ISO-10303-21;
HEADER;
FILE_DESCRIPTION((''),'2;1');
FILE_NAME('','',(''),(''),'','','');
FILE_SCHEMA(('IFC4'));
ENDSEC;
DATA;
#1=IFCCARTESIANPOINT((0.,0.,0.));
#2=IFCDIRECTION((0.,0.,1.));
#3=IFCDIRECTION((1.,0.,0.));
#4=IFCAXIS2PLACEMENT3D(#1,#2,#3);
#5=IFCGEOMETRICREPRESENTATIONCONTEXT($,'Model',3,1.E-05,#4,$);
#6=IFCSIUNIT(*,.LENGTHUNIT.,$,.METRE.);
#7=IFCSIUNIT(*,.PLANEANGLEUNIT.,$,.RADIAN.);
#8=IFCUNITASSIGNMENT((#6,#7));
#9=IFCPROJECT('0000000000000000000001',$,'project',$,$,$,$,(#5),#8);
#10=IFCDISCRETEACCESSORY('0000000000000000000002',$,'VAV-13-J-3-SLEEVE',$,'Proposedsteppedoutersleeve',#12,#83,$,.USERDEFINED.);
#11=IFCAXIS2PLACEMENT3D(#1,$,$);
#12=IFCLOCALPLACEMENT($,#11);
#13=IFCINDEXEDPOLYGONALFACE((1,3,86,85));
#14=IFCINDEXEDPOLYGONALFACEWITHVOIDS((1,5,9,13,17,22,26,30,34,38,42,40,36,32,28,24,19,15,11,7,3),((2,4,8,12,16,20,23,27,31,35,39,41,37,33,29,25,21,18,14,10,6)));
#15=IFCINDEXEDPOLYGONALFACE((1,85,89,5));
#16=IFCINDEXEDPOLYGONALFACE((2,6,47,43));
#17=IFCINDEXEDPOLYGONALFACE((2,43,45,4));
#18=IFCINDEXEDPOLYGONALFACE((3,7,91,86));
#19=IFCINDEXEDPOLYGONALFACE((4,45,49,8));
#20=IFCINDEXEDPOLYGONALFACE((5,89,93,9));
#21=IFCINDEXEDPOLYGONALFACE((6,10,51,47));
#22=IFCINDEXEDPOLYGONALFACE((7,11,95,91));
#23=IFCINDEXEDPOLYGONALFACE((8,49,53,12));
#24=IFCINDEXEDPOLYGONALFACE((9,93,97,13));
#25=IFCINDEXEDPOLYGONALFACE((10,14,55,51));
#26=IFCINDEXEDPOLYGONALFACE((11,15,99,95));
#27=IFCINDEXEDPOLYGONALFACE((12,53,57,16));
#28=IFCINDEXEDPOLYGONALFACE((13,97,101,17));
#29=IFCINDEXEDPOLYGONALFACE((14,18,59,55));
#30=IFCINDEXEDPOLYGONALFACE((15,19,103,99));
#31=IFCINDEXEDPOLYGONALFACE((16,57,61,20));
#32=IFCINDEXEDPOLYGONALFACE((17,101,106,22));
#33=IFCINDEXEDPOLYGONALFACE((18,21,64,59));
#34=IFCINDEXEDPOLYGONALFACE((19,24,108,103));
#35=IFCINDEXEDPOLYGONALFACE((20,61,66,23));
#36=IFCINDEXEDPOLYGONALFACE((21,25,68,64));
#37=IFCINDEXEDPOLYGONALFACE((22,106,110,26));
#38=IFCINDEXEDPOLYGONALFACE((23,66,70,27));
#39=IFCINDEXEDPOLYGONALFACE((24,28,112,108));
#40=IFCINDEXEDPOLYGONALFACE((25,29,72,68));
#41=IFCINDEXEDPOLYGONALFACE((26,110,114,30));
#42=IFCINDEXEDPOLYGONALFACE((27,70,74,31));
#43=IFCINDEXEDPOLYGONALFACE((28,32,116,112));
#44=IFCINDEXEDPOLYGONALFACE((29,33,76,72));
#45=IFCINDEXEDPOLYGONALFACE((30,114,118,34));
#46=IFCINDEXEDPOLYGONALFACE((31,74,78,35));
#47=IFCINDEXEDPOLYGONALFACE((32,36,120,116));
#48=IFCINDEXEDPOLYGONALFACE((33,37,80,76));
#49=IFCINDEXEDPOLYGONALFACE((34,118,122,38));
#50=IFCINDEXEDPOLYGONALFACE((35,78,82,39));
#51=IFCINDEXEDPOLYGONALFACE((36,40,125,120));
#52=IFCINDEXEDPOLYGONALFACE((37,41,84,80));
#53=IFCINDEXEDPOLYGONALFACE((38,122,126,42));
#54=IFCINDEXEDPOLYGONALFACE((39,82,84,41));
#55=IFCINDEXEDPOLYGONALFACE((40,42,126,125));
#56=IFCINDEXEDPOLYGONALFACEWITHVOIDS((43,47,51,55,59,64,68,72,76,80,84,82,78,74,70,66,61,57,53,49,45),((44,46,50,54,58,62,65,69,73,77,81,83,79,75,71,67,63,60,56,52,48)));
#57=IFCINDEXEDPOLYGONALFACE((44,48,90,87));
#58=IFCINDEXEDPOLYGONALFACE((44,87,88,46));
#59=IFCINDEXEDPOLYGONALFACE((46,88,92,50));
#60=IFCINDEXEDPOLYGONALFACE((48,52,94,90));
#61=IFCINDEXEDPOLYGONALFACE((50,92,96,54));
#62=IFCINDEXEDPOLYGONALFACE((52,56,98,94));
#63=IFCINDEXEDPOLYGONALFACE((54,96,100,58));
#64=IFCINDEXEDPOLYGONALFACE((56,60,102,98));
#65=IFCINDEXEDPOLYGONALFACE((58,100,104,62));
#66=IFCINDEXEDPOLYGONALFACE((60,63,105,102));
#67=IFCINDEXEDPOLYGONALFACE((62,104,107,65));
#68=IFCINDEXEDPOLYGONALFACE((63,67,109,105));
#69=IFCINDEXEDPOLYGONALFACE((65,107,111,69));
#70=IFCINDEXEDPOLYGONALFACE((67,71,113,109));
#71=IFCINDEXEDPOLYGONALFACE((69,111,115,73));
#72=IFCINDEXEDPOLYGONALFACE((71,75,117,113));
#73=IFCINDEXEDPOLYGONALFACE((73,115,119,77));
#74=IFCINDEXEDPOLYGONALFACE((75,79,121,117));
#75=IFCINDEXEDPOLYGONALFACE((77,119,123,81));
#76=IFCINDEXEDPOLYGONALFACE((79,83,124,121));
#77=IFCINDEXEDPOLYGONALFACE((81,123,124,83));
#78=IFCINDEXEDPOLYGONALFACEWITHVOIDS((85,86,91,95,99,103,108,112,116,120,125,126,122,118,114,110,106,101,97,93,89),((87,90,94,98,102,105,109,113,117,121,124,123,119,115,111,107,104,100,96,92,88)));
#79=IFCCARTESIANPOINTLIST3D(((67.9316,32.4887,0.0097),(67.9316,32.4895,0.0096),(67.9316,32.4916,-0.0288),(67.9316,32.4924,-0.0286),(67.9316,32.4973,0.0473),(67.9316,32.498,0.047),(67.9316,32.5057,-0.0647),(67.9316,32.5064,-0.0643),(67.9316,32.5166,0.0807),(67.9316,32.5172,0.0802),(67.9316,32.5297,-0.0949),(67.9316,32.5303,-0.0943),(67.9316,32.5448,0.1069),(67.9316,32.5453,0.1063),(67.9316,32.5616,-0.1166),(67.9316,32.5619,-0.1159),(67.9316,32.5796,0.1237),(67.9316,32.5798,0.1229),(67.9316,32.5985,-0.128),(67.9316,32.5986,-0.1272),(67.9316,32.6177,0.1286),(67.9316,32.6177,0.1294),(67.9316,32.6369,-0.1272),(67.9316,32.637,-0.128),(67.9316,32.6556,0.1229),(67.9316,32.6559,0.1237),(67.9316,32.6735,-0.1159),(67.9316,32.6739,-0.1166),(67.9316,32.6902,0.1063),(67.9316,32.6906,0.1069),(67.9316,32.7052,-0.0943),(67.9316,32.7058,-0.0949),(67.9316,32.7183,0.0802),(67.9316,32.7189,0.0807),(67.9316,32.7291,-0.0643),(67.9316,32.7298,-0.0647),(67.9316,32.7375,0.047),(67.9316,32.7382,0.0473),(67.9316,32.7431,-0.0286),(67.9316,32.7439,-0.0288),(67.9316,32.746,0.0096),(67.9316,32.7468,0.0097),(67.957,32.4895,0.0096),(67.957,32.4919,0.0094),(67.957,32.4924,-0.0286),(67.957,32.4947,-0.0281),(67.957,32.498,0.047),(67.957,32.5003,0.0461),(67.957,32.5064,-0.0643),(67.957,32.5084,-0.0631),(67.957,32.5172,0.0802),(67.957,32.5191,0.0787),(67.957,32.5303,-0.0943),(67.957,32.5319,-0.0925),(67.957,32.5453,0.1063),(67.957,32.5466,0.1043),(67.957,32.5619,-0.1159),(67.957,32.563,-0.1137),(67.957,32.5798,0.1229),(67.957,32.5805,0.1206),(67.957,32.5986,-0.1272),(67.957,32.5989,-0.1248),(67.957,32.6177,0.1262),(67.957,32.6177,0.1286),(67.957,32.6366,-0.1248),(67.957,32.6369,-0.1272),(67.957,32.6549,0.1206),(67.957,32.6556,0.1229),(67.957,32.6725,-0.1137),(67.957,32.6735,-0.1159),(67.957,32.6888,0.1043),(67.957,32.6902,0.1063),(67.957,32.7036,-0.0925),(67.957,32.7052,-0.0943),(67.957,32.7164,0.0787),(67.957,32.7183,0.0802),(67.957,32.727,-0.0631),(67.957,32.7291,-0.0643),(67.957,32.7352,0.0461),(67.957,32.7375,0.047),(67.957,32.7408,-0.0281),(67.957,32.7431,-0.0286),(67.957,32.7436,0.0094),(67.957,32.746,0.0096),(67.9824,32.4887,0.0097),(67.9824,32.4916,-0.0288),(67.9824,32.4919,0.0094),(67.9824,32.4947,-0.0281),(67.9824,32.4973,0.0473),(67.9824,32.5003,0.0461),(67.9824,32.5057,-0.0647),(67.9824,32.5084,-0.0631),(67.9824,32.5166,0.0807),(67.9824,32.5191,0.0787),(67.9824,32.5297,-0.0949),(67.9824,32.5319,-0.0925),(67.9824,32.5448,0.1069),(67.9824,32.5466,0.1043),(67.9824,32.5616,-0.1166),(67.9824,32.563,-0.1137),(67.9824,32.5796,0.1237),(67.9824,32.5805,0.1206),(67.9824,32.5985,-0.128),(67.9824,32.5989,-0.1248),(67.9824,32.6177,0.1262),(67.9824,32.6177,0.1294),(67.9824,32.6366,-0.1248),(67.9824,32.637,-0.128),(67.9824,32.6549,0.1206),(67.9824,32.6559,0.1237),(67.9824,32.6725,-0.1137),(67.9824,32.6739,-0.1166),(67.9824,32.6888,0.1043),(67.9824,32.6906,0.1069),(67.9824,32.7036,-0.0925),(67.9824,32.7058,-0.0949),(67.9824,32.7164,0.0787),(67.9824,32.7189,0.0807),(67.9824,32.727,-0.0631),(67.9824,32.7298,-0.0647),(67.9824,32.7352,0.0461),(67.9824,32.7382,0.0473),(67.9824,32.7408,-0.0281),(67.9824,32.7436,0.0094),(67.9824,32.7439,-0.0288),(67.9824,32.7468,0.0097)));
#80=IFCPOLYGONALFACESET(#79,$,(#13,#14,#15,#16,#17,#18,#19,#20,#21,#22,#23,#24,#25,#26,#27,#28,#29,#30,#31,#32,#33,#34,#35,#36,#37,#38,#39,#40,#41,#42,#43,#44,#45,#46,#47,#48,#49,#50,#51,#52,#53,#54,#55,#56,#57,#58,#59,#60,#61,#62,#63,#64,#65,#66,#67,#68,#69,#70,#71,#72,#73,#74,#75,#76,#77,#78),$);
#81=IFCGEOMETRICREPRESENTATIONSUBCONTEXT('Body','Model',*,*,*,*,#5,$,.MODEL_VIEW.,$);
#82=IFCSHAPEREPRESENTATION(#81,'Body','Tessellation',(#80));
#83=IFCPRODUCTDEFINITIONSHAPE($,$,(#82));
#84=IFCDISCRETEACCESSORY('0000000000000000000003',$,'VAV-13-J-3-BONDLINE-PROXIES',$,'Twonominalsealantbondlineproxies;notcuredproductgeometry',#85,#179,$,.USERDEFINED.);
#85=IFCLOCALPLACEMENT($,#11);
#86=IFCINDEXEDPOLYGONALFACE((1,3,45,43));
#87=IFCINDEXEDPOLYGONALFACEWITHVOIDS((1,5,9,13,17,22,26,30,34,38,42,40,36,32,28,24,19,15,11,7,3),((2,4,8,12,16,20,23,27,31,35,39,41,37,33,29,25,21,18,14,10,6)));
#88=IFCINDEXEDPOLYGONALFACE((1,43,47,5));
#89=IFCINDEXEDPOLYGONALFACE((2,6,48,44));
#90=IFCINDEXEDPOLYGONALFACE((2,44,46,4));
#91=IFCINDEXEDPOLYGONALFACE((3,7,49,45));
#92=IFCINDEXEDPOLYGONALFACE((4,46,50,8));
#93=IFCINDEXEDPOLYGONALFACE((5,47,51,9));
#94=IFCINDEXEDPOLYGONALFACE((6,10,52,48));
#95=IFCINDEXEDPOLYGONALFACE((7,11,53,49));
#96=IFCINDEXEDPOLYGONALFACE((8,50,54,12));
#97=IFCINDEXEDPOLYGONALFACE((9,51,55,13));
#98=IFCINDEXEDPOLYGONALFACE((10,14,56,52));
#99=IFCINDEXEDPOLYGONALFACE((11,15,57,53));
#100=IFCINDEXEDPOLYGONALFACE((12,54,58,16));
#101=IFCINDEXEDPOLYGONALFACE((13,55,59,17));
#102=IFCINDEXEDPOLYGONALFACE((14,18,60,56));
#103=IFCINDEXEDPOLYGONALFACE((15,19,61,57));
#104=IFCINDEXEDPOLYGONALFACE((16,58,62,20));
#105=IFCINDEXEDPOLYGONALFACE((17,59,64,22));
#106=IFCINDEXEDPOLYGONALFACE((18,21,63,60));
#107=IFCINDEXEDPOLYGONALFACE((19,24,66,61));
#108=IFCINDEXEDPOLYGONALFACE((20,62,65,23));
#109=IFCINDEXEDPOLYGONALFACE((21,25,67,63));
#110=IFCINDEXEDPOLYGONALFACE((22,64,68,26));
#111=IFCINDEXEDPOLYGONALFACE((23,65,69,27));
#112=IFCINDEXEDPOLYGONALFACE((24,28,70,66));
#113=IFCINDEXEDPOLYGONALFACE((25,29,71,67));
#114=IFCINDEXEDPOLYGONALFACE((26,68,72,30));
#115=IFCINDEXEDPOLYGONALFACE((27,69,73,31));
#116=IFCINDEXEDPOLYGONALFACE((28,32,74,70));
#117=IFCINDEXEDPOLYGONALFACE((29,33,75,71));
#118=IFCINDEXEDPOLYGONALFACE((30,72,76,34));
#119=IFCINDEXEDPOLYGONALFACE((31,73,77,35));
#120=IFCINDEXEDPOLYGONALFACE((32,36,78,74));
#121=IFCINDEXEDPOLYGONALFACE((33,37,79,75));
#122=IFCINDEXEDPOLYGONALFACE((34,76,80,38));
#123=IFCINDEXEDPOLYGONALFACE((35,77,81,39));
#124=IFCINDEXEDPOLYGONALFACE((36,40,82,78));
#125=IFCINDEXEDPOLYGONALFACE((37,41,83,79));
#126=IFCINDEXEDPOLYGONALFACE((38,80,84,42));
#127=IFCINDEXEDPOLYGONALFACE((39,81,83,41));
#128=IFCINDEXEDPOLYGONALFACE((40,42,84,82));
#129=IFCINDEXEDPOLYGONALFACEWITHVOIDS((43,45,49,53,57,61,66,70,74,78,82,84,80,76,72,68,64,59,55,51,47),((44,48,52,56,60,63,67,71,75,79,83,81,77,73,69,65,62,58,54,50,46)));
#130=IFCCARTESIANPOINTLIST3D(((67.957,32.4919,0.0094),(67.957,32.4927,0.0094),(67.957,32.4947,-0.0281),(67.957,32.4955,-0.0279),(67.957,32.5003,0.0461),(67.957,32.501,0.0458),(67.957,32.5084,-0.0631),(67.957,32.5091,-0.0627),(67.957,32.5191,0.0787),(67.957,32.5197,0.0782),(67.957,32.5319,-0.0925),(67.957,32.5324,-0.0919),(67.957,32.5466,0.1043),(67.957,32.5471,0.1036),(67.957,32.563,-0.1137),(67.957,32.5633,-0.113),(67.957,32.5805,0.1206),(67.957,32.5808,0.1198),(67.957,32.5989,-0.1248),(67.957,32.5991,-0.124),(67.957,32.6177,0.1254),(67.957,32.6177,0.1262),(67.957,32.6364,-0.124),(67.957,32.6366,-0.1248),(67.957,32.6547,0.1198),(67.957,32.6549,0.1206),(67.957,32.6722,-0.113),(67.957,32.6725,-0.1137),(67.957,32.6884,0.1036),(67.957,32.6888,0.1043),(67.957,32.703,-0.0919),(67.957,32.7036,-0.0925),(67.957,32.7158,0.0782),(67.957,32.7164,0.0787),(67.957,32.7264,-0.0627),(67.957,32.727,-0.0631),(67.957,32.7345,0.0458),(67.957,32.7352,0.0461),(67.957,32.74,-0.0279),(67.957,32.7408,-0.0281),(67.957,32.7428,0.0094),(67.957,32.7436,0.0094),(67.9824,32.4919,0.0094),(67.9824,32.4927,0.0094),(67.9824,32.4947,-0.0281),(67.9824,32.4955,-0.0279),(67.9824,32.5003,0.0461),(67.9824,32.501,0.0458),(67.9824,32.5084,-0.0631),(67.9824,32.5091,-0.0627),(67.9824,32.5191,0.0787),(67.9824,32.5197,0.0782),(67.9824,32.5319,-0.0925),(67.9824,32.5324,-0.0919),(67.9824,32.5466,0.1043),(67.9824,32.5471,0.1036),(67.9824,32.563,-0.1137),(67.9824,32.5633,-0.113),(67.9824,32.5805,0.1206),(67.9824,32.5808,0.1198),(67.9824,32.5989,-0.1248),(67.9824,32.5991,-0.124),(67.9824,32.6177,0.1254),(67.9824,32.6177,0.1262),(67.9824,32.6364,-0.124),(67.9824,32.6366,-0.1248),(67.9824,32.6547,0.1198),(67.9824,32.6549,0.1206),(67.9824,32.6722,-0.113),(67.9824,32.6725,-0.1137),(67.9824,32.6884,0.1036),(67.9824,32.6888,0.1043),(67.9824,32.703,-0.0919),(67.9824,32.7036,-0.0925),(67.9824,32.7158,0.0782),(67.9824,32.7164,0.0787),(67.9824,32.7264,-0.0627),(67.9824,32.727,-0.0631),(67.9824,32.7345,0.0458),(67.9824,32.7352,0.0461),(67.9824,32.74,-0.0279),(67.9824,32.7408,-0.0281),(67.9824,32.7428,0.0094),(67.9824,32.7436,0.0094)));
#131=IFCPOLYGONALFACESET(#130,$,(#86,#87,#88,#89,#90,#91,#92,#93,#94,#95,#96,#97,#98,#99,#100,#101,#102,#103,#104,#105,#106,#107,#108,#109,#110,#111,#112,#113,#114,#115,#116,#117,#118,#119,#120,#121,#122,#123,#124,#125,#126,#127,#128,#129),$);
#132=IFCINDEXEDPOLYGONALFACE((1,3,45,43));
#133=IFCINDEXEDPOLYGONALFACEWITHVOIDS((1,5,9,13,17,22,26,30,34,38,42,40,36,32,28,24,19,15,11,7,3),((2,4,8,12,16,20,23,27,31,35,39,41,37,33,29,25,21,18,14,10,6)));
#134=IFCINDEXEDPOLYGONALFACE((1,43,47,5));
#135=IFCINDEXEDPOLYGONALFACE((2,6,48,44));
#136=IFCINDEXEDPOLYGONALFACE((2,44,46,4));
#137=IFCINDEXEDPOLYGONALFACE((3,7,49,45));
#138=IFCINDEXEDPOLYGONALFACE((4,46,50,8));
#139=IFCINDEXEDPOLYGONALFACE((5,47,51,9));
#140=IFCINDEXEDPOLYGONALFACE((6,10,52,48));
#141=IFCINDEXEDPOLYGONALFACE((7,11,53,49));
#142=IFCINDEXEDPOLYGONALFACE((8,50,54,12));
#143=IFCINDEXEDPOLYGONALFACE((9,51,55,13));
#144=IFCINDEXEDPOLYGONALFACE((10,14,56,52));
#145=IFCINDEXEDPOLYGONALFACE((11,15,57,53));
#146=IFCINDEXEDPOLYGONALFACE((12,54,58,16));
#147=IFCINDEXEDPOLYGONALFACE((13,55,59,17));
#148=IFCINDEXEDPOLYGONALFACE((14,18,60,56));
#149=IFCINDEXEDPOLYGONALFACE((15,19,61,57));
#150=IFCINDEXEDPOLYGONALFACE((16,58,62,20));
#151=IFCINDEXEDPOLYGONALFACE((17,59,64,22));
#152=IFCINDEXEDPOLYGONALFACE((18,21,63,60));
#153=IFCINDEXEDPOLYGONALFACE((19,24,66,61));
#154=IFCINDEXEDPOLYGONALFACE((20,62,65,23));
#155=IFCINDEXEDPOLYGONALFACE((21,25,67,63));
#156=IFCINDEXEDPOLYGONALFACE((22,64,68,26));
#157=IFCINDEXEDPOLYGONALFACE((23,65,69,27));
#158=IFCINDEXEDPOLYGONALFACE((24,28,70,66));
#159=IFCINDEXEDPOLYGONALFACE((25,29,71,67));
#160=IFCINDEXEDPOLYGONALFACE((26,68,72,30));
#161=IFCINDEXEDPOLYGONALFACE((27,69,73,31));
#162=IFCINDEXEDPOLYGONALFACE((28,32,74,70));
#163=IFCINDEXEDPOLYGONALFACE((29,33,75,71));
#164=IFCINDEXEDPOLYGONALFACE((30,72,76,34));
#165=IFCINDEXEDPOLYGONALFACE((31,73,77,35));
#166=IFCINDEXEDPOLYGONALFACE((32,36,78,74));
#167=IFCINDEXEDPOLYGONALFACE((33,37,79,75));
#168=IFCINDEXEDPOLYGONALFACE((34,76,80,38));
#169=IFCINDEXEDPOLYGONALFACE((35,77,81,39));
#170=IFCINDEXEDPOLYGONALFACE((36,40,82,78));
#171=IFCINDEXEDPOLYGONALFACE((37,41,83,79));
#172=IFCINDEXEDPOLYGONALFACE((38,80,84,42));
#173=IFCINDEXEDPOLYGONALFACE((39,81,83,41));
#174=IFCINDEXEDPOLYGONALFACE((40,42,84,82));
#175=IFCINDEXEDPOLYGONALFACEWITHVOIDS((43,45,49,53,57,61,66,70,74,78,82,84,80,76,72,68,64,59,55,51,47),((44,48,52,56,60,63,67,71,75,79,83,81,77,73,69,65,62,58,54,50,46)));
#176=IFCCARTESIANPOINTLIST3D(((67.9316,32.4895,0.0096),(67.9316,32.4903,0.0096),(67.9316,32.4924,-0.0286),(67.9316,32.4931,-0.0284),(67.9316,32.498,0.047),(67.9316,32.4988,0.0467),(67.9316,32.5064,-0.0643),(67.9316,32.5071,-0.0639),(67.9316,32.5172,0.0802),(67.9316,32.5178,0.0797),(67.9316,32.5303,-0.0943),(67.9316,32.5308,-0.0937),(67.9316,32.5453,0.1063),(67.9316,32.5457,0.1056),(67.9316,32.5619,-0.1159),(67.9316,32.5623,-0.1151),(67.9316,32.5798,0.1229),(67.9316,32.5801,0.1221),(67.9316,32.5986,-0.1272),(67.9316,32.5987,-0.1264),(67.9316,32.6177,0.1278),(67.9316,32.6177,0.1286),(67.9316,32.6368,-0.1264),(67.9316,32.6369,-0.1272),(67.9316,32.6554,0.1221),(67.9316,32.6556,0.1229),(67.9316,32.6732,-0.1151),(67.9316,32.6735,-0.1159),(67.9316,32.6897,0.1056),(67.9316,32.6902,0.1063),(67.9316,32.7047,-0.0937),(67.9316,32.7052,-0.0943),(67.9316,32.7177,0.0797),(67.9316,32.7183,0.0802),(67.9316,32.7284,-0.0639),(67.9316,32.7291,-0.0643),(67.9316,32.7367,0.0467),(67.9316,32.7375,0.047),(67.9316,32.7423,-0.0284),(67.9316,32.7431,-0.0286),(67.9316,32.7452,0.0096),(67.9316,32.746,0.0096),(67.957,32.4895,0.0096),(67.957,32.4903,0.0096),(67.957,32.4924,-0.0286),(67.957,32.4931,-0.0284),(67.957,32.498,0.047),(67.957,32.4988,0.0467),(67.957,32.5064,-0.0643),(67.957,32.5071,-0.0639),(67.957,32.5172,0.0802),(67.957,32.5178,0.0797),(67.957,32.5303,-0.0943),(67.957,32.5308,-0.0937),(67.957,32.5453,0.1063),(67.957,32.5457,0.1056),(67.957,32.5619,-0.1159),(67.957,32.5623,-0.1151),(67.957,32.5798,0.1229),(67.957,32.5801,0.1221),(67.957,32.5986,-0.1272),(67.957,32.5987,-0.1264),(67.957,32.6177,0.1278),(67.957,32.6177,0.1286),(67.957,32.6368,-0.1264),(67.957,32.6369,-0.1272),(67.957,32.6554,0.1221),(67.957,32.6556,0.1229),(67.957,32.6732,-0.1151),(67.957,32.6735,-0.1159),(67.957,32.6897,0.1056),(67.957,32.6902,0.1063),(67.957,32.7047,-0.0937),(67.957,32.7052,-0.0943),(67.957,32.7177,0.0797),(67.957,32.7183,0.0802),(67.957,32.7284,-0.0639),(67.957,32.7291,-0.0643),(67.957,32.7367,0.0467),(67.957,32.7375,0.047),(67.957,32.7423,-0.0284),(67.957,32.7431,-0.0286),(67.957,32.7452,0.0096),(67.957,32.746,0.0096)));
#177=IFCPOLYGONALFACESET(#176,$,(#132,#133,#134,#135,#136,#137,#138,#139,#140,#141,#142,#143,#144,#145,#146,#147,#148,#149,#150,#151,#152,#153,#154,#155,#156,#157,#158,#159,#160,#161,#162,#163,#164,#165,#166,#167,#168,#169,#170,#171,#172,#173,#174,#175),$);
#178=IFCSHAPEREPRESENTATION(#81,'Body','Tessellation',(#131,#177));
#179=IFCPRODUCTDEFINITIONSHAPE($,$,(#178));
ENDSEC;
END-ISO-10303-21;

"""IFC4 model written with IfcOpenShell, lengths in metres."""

from ifc_helpers import new_model, entity, si_unit, frame, origin_with_axes, place, context, subcontext, project, element, save


model = new_model("IFC4")

# Units and contexts
model_context = context("Model", 3, precision=1e-05, world=origin_with_axes())
body_context = subcontext(model_context, "Body", "Model", "MODEL_VIEW")
ifc_project = project(units=[si_unit("LENGTHUNIT", "METRE"), si_unit("PLANEANGLEUNIT", "RADIAN")], contexts=[model_context])

# Discrete accessories
discrete_accessory_1_placement = place(None, frame((67.957, 32.6177, 0.0), z_axis=(0.0, -1.0, 0.0), x_axis=(0.0, 0.0, 1.0)))
element("IfcDiscreteAccessory", 1, at=discrete_accessory_1_placement, Name="VAV-13-J-3-SLEEVE", ObjectType="Proposedsteppedoutersleeve", PredefinedType="USERDEFINED", context=body_context, shape_type="SweptSolid", body=[
    entity("IfcRevolvedAreaSolid", entity("IfcArbitraryClosedProfileDef", "AREA", None, entity("IfcPolyline", [entity("IfcCartesianPoint", [0.1262, -0.0254]), entity("IfcCartesianPoint", [0.1294, -0.0254]), entity("IfcCartesianPoint", [0.1294, 0.0254]), entity("IfcCartesianPoint", [0.1286, 0.0254]), entity("IfcCartesianPoint", [0.1286, 0.0]), entity("IfcCartesianPoint", [0.1262, 0.0]), entity("IfcCartesianPoint", [0.1262, -0.0254])])), entity("IfcAxis2Placement3D", entity("IfcCartesianPoint", [0.0, 0.0, 0.0])), entity("IfcAxis1Placement", entity("IfcCartesianPoint", [0.0, 0.0, 0.0]), entity("IfcDirection", [0.0, 1.0, 0.0])), 6.283185),
])
discrete_accessory_2_placement = place(None, frame((67.957, 32.6177, 0.0), z_axis=(0.0, -1.0, 0.0), x_axis=(0.0, 0.0, 1.0)))
element("IfcDiscreteAccessory", 2, at=discrete_accessory_2_placement, Name="VAV-13-J-3-BONDLINE-PROXIES", ObjectType="Twonominalsealantbondlineproxies;notcuredproductgeometry", PredefinedType="USERDEFINED", context=body_context, shape_type="SweptSolid", body=[
    entity("IfcRevolvedAreaSolid", entity("IfcArbitraryClosedProfileDef", "AREA", None, entity("IfcPolyline", [entity("IfcCartesianPoint", [0.1254, -0.0254]), entity("IfcCartesianPoint", [0.1262, -0.0254]), entity("IfcCartesianPoint", [0.1262, 0.0]), entity("IfcCartesianPoint", [0.1254, 0.0]), entity("IfcCartesianPoint", [0.1254, -0.0254])])), entity("IfcAxis2Placement3D", entity("IfcCartesianPoint", [0.0, 0.0, 0.0])), entity("IfcAxis1Placement", entity("IfcCartesianPoint", [0.0, 0.0, 0.0]), entity("IfcDirection", [0.0, 1.0, 0.0])), 6.283185),
    entity("IfcRevolvedAreaSolid", entity("IfcArbitraryClosedProfileDef", "AREA", None, entity("IfcPolyline", [entity("IfcCartesianPoint", [0.1278, 0.0]), entity("IfcCartesianPoint", [0.1286, 0.0]), entity("IfcCartesianPoint", [0.1286, 0.0254]), entity("IfcCartesianPoint", [0.1278, 0.0254]), entity("IfcCartesianPoint", [0.1278, 0.0])])), entity("IfcAxis2Placement3D", entity("IfcCartesianPoint", [0.0, 0.0, 0.0])), entity("IfcAxis1Placement", entity("IfcCartesianPoint", [0.0, 0.0, 0.0]), entity("IfcDirection", [0.0, 1.0, 0.0])), 6.283185),
])

save(model, "model.ifc")
